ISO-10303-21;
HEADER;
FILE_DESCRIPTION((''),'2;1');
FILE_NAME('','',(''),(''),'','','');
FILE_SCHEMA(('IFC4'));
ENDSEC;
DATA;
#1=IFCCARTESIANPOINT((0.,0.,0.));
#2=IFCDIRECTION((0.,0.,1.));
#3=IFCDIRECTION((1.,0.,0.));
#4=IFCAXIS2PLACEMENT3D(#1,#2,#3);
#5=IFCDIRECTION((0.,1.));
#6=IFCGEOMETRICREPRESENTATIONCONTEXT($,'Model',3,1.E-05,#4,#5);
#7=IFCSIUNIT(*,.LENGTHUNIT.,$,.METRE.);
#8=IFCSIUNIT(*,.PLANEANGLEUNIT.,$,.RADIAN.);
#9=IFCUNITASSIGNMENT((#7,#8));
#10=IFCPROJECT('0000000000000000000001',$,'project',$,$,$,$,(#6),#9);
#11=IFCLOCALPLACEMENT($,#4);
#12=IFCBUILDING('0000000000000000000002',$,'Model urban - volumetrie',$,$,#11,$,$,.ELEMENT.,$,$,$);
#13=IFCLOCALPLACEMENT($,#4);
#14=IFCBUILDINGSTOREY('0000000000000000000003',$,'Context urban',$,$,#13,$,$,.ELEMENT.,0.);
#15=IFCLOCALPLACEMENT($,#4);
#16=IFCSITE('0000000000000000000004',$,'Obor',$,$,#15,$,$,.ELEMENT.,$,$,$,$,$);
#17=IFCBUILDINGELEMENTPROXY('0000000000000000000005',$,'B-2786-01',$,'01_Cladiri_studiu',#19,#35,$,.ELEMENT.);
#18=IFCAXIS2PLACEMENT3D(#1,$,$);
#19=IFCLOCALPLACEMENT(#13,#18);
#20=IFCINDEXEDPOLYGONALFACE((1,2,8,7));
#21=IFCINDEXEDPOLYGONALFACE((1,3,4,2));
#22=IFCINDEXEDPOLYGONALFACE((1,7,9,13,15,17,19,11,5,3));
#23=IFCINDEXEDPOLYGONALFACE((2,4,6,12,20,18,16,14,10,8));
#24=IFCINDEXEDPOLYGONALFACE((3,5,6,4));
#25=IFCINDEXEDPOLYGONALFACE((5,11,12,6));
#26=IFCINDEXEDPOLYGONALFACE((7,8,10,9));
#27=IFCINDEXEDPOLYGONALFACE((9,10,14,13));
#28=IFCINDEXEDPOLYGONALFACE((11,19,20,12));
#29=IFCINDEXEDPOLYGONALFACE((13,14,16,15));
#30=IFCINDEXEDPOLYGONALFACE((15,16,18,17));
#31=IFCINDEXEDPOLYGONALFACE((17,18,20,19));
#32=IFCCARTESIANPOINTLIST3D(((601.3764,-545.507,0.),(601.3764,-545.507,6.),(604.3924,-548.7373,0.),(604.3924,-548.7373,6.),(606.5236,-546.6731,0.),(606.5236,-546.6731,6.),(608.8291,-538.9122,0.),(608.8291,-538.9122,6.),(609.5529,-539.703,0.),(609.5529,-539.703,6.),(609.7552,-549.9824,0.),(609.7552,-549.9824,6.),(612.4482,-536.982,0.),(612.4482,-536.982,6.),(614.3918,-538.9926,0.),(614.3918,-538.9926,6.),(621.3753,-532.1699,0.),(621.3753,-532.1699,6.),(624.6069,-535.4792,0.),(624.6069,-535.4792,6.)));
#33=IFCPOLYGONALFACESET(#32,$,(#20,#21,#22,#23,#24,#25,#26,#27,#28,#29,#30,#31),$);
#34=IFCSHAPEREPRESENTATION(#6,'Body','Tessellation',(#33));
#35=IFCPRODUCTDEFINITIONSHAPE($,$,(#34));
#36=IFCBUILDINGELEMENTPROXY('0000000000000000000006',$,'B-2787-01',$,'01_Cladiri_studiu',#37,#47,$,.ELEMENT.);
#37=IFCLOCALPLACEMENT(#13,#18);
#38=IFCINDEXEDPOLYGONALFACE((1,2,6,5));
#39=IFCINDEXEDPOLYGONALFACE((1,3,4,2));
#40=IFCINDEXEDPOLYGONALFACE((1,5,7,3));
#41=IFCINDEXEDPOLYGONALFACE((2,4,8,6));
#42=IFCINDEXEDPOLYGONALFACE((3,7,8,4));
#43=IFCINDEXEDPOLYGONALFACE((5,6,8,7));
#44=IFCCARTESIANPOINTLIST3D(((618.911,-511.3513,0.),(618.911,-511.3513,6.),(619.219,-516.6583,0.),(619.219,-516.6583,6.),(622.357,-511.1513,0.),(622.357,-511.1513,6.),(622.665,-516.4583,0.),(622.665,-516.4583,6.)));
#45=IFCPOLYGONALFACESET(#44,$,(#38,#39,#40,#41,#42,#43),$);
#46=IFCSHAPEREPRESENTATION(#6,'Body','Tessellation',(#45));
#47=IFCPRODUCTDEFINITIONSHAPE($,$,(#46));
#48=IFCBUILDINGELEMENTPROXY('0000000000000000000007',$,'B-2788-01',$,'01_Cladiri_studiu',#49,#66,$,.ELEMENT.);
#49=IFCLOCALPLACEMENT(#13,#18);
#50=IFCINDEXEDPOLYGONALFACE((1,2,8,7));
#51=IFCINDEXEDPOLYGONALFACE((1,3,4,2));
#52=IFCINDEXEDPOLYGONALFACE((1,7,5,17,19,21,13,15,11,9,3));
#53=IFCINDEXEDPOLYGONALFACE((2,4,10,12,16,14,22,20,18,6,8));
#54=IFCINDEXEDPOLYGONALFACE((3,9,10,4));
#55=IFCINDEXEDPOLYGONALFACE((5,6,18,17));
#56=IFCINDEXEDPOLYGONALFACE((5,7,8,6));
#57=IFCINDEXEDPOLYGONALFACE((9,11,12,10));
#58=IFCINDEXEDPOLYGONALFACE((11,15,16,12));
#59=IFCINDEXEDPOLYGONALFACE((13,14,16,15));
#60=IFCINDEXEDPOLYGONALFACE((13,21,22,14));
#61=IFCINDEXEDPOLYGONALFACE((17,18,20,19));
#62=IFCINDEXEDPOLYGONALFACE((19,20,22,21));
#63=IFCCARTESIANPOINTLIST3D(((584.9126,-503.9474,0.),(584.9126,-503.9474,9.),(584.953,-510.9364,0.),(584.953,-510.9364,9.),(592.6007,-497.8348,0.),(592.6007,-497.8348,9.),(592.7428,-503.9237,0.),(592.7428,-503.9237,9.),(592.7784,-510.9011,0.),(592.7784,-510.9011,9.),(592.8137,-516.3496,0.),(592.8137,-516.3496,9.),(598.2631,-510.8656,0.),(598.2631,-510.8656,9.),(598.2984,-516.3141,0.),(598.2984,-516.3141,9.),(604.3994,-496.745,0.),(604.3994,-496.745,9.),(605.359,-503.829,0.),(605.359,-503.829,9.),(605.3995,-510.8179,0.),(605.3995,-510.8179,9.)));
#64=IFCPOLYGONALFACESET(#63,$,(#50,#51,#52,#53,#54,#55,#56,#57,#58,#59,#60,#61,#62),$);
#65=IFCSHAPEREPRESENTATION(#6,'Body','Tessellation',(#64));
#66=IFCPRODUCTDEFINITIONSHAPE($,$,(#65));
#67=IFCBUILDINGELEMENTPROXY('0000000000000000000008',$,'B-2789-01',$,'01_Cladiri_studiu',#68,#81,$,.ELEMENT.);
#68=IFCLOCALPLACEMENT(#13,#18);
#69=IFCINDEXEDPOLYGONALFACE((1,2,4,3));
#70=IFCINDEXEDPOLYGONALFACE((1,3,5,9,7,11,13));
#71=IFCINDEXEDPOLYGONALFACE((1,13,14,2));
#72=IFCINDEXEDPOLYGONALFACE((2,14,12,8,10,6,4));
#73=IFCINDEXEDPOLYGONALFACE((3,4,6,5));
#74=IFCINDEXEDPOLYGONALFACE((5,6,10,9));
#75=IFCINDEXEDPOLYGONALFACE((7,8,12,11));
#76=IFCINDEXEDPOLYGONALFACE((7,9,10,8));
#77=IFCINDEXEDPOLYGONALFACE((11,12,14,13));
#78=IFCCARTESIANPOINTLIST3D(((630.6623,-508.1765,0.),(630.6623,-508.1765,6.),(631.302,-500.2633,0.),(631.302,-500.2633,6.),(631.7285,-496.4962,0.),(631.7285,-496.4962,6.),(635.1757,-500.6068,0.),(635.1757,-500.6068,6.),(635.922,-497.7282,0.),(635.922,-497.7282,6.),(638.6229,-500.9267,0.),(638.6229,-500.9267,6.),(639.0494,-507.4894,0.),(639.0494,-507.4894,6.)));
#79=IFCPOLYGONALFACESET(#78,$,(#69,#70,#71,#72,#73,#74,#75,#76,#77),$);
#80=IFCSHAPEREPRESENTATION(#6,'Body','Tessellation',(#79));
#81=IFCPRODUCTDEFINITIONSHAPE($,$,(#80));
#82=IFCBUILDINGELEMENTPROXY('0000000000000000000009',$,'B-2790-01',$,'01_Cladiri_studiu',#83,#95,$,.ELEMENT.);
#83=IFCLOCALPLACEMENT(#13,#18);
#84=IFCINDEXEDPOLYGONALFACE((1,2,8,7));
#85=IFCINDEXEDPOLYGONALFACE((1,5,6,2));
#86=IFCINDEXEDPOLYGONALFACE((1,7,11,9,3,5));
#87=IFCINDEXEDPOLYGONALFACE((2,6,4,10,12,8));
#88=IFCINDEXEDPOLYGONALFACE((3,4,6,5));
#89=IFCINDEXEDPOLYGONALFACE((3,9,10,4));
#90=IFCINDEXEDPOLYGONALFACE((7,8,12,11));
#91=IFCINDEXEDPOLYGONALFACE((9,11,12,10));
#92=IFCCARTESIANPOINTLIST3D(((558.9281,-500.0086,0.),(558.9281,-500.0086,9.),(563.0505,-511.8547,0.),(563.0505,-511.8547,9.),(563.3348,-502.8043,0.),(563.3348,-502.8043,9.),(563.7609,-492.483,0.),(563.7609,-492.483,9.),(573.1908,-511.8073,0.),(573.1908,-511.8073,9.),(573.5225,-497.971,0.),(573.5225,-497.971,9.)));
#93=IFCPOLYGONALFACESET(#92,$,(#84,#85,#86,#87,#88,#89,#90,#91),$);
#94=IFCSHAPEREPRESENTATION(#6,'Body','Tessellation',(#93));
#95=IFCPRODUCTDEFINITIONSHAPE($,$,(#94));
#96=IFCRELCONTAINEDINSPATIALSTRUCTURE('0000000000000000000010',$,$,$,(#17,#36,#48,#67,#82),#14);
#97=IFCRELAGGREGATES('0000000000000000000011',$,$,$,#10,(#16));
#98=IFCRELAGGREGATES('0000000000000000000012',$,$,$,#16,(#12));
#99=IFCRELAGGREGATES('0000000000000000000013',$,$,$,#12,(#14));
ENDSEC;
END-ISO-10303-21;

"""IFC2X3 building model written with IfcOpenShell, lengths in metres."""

from ifc_helpers import new_model, si_unit, direction, origin_with_axes, place, context, project, spatial, polyline, outline, extrude, element, save


model = new_model("IFC2X3")

# Units and contexts
model_context = context("Model", 3, precision=1e-05, world=origin_with_axes(), true_north=direction((0.0, 1.0)))
ifc_project = project(units=[si_unit("LENGTHUNIT", "METRE"), si_unit("PLANEANGLEUNIT", "RADIAN")], contexts=[model_context])

# Site, building, storey
site_placement = place(None, origin_with_axes())
site = spatial("IfcSite", under=ifc_project, at=site_placement, Name="Obor", CompositionType="ELEMENT")
building_placement = place(None, origin_with_axes())
building = spatial("IfcBuilding", under=site, at=building_placement, Name="Model urban - volumetrie", CompositionType="ELEMENT")
storey_placement = place(None, origin_with_axes())
storey = spatial("IfcBuildingStorey", under=building, at=storey_placement, Name="Context urban", CompositionType="ELEMENT", Elevation=0.0)

# Building element proxies
proxy_1_placement = place(None, origin_with_axes())
element("IfcBuildingElementProxy", 1, at=proxy_1_placement, inside=storey, Name="B-2786-01", ObjectType="01_Cladiri_studiu", CompositionType="ELEMENT", context=model_context, shape_type="SweptSolid", body=[
    extrude(outline(polyline([(608.8291, -538.9122), (601.3764, -545.507), (604.3924, -548.7373), (606.5236, -546.6731), (609.7552, -549.9824), (624.6069, -535.4792), (621.3753, -532.1699), (614.3918, -538.9926), (612.4482, -536.982), (609.5529, -539.703), (608.8291, -538.9122)])), origin_with_axes(), (0.0, 0.0, 1.0), 6.0),
])
proxy_2_placement = place(None, origin_with_axes())
element("IfcBuildingElementProxy", 2, at=proxy_2_placement, inside=storey, Name="B-2787-01", ObjectType="01_Cladiri_studiu", CompositionType="ELEMENT", context=model_context, shape_type="SweptSolid", body=[
    extrude(outline(polyline([(622.665, -516.4583), (622.357, -511.1513), (618.911, -511.3513), (619.219, -516.6583), (622.665, -516.4583)])), origin_with_axes(), (0.0, 0.0, 1.0), 6.0),
])
proxy_3_placement = place(None, origin_with_axes())
element("IfcBuildingElementProxy", 3, at=proxy_3_placement, inside=storey, Name="B-2788-01", ObjectType="01_Cladiri_studiu", CompositionType="ELEMENT", context=model_context, shape_type="SweptSolid", body=[
    extrude(outline(polyline([(592.8137, -516.3496), (598.2984, -516.3141), (598.2631, -510.8656), (605.3995, -510.8179), (605.359, -503.829), (604.3994, -496.745), (592.6007, -497.8348), (592.7428, -503.9237), (584.9126, -503.9474), (584.953, -510.9364), (592.7784, -510.9011), (592.8137, -516.3496)])), origin_with_axes(), (0.0, 0.0, 1.0), 9.0),
])
proxy_4_placement = place(None, origin_with_axes())
element("IfcBuildingElementProxy", 4, at=proxy_4_placement, inside=storey, Name="B-2789-01", ObjectType="01_Cladiri_studiu", CompositionType="ELEMENT", context=model_context, shape_type="SweptSolid", body=[
    extrude(outline(polyline([(635.1757, -500.6068), (635.922, -497.7282), (631.7285, -496.4962), (631.302, -500.2633), (630.6623, -508.1765), (639.0494, -507.4894), (638.6229, -500.9267), (635.1757, -500.6068)])), origin_with_axes(), (0.0, 0.0, 1.0), 6.0),
])
proxy_5_placement = place(None, origin_with_axes())
element("IfcBuildingElementProxy", 5, at=proxy_5_placement, inside=storey, Name="B-2790-01", ObjectType="01_Cladiri_studiu", CompositionType="ELEMENT", context=model_context, shape_type="SweptSolid", body=[
    extrude(outline(polyline([(573.1908, -511.8073), (573.5225, -497.971), (563.7609, -492.483), (558.9281, -500.0086), (563.3348, -502.8043), (563.0505, -511.8547), (573.1908, -511.8073)])), origin_with_axes(), (0.0, 0.0, 1.0), 9.0),
])

save(model, "model.ifc")
